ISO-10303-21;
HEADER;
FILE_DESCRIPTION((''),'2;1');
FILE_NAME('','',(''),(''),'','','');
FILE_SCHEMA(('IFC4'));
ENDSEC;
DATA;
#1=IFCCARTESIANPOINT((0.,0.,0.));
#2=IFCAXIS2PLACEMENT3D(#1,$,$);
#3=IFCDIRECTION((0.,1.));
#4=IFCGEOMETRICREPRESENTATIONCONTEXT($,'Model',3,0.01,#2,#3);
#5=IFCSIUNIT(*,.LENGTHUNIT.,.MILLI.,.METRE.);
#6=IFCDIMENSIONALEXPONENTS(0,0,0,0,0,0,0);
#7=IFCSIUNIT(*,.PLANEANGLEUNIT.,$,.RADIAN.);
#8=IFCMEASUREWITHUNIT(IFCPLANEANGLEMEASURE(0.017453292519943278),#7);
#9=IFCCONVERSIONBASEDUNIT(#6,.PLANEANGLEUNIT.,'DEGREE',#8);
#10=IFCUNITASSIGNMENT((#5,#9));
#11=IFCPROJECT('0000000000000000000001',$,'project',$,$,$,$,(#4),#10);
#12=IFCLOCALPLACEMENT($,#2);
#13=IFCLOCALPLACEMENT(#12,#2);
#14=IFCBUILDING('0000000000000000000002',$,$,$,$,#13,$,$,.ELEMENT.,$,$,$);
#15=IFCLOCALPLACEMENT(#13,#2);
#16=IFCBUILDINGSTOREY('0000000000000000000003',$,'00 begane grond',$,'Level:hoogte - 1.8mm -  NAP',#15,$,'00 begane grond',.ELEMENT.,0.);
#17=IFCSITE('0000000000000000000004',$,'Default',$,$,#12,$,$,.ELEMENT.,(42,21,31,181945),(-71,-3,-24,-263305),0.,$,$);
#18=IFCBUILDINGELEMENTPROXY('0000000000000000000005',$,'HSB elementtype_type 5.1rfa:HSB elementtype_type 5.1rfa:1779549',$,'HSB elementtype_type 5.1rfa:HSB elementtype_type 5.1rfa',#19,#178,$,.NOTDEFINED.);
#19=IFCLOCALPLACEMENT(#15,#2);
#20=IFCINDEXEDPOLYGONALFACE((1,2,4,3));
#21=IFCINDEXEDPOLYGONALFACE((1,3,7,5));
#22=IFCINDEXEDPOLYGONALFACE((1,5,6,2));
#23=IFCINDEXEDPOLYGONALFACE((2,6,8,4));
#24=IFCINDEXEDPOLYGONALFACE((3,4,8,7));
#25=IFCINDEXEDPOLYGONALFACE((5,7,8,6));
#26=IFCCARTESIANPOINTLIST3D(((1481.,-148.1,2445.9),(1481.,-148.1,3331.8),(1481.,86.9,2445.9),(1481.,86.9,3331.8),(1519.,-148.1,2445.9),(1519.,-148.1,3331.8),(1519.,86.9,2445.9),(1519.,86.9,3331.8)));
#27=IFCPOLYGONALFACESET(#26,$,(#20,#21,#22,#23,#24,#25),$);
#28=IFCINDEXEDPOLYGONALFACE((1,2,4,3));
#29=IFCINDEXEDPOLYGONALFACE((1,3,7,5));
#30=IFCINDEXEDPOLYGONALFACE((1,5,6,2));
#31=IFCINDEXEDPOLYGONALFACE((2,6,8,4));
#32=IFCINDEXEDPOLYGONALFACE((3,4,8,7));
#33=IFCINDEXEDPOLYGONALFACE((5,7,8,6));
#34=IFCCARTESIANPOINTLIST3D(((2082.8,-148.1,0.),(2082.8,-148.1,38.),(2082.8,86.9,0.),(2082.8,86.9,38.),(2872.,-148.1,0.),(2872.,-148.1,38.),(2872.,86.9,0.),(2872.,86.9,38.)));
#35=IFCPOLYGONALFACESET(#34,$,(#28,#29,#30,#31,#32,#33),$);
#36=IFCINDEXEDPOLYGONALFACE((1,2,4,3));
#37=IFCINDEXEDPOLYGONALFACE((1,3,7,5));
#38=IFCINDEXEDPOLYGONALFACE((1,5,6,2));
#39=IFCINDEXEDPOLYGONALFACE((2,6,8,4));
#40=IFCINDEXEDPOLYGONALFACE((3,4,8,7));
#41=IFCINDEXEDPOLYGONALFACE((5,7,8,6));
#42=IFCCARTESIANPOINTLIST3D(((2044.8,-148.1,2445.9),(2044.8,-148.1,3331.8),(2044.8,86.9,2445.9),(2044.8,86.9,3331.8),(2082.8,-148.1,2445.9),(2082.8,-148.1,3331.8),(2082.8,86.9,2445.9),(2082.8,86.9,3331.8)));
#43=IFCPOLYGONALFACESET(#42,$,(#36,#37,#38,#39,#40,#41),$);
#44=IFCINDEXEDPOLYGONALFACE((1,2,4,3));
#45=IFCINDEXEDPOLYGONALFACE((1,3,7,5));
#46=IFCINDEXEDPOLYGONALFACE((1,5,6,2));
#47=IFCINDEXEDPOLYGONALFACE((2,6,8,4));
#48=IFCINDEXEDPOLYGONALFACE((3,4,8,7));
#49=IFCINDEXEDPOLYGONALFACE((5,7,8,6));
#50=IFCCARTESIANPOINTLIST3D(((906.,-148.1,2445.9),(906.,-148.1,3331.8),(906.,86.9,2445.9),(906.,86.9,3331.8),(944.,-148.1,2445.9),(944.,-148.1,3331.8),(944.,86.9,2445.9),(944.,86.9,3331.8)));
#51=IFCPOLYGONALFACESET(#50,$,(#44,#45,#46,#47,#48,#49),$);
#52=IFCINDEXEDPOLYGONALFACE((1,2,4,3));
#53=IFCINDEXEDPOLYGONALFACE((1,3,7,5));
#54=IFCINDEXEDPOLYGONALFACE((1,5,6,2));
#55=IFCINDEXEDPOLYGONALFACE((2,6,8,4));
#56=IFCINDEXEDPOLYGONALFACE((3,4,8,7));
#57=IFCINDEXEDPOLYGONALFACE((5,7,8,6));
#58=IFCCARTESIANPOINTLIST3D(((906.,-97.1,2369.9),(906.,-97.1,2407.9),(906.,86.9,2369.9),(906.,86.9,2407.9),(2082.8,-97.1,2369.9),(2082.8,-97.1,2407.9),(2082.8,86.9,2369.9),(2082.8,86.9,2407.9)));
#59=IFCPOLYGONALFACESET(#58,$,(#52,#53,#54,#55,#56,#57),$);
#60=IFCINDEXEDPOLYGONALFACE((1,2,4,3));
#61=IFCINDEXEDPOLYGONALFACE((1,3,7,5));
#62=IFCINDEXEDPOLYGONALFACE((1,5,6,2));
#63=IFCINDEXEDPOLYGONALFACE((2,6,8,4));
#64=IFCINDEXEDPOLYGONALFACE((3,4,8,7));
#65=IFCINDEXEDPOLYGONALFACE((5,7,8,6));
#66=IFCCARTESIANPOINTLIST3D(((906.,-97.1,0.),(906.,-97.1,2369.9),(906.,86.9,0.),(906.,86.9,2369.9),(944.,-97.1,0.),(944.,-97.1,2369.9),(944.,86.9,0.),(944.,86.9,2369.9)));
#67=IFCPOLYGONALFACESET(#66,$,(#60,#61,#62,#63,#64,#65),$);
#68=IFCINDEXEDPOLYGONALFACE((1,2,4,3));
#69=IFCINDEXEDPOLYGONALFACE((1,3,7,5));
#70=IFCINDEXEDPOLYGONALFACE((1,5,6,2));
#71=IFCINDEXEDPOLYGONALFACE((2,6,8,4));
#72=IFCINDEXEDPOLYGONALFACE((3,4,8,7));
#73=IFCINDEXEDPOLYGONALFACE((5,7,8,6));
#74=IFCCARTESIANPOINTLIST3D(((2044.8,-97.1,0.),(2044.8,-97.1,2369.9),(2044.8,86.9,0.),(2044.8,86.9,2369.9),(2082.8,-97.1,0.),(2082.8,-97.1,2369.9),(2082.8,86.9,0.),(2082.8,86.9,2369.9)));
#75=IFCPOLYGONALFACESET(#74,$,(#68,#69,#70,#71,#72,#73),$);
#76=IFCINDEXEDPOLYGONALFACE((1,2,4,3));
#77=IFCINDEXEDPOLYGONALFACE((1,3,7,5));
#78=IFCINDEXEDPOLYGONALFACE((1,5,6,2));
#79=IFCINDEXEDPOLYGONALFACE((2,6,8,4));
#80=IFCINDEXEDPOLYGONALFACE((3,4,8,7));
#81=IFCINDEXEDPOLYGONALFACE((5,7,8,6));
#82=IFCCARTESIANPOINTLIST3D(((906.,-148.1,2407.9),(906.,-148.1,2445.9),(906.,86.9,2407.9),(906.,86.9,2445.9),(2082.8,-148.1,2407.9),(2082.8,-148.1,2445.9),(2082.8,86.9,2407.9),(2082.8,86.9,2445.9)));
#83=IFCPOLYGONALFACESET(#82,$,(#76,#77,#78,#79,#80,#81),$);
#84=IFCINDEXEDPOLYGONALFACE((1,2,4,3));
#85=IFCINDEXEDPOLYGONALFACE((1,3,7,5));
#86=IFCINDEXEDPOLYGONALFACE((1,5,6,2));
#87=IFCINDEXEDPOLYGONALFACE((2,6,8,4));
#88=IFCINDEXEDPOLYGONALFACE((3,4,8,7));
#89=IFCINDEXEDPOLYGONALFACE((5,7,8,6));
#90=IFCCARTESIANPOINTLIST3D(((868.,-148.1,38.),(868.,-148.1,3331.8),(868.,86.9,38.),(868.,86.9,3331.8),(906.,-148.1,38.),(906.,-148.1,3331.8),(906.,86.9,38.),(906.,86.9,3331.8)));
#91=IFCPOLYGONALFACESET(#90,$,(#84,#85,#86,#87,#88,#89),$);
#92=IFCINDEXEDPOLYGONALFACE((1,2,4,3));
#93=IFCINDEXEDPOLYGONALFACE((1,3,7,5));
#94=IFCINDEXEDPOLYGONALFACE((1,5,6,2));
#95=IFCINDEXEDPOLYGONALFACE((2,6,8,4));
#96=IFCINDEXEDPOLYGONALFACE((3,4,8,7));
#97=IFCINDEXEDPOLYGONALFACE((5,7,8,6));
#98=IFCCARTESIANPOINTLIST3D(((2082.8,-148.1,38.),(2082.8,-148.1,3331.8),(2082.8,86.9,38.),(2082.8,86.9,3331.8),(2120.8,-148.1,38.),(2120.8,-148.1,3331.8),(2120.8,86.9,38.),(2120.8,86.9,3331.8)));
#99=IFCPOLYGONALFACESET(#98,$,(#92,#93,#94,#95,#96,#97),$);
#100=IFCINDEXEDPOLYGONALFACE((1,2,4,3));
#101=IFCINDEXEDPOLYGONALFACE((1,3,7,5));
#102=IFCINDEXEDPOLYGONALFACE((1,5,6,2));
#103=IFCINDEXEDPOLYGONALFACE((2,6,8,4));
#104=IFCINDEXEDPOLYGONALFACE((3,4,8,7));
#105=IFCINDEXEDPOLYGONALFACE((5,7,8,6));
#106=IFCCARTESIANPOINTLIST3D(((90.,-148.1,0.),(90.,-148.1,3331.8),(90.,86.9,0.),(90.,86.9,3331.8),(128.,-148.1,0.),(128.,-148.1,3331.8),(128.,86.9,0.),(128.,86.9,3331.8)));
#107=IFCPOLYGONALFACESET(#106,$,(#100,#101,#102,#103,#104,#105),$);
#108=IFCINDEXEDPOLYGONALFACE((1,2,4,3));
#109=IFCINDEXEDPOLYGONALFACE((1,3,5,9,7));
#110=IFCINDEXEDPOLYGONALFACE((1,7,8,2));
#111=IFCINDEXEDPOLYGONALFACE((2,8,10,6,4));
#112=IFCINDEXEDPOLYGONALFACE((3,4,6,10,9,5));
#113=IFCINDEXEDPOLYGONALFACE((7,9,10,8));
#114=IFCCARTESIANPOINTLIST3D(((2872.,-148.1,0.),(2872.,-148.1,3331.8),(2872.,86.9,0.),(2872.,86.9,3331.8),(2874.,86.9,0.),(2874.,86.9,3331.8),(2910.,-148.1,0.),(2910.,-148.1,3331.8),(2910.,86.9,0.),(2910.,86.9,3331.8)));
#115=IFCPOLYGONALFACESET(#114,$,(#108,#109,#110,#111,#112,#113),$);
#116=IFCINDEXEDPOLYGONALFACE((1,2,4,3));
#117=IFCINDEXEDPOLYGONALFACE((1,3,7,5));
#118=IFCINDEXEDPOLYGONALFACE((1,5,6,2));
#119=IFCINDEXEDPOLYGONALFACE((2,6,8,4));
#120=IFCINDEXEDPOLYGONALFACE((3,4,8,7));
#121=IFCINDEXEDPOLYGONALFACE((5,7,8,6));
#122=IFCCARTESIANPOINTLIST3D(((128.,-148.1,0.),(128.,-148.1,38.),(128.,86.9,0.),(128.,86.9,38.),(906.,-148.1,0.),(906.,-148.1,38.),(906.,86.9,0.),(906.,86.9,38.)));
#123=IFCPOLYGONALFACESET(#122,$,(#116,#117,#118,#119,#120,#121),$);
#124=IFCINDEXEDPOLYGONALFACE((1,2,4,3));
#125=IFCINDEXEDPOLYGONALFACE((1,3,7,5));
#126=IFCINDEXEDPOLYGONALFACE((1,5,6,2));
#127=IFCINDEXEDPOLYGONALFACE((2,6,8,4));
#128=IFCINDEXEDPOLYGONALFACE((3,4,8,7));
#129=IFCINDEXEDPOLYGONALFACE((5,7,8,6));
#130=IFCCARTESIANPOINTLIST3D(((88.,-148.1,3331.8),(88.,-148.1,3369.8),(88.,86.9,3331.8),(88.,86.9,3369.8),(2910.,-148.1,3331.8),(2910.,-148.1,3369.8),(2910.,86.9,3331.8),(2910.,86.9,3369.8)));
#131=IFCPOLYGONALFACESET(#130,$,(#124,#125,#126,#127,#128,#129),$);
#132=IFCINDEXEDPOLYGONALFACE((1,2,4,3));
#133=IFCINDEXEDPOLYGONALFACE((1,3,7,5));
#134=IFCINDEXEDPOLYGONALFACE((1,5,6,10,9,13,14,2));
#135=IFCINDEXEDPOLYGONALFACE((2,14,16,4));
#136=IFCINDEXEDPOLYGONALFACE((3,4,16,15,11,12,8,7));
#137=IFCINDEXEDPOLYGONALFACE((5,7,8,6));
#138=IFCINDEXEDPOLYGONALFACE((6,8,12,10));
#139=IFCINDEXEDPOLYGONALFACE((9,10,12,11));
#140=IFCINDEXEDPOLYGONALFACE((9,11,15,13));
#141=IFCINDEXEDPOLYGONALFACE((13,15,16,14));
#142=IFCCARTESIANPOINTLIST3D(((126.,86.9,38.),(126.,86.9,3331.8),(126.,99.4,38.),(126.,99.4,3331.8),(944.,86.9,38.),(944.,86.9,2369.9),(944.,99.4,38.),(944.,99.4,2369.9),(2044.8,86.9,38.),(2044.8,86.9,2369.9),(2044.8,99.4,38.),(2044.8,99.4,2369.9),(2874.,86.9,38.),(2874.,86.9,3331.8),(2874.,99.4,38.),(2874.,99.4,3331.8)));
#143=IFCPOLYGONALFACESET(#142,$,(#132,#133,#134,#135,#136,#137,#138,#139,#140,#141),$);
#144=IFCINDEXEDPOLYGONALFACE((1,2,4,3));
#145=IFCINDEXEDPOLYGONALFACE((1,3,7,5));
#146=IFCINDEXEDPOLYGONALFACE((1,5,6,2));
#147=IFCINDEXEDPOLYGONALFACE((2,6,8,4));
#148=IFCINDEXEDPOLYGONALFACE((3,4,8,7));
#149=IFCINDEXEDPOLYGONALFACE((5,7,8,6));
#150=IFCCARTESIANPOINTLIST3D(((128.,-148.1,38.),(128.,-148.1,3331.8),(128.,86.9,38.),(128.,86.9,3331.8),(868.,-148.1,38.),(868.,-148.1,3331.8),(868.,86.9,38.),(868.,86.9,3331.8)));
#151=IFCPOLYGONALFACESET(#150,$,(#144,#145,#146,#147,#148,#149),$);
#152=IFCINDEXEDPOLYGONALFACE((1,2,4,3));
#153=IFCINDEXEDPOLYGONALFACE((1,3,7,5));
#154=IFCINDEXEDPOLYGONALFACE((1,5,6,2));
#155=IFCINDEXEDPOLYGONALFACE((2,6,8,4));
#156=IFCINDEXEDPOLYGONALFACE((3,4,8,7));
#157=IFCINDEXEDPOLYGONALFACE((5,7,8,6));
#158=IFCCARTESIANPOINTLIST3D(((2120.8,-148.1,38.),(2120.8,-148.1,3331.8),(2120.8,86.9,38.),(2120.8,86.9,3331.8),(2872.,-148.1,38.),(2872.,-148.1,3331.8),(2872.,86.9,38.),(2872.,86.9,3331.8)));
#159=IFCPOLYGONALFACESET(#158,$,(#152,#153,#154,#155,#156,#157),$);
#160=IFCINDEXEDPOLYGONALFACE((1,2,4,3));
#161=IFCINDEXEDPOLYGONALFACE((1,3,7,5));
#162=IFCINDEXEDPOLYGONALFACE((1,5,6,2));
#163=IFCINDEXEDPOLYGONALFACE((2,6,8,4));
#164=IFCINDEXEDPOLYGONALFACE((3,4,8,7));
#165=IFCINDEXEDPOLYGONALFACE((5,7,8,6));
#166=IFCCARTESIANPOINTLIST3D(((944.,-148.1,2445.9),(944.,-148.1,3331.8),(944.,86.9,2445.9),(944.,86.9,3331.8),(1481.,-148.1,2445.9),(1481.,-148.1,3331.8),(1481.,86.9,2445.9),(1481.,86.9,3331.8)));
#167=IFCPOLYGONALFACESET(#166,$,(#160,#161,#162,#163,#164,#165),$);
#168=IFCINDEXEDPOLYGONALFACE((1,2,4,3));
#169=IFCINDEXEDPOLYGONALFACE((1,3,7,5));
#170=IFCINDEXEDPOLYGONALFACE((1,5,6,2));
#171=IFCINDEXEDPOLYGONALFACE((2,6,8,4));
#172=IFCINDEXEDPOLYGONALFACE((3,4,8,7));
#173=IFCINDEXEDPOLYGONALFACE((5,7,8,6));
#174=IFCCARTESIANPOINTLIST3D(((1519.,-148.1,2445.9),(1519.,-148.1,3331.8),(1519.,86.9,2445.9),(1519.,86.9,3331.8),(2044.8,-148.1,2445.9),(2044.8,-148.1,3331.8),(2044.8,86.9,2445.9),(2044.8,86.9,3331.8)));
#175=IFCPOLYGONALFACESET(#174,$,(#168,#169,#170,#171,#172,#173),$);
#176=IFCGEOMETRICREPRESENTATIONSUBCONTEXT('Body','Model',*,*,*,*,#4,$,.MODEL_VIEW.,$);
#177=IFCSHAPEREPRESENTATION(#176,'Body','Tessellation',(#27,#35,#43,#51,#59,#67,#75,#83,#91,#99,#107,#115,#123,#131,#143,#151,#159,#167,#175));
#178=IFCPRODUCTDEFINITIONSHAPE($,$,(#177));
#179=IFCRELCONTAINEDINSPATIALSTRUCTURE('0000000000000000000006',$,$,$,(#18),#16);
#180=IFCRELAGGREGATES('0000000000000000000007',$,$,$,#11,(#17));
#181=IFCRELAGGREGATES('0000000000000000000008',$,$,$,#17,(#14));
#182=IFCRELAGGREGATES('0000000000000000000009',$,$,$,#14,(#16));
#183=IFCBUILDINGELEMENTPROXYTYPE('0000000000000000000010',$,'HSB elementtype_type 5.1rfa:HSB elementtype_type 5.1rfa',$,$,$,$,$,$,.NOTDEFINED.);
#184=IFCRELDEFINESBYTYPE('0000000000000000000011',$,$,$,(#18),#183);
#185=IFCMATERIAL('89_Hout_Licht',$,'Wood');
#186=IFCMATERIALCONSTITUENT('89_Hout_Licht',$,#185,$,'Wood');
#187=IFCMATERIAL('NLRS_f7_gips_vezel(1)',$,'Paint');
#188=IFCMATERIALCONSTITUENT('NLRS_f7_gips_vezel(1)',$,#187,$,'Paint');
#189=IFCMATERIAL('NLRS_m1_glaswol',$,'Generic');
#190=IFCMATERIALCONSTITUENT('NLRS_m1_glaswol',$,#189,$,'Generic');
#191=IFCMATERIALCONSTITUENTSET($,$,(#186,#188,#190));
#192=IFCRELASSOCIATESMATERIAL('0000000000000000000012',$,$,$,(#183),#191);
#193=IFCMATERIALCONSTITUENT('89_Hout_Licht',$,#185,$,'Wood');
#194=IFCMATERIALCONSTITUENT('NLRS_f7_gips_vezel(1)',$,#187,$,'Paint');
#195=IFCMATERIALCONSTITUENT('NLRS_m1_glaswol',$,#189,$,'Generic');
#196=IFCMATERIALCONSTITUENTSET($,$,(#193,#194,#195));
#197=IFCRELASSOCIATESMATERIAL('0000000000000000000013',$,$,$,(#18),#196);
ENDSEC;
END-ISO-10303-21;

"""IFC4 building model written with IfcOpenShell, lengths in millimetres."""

from ifc_helpers import new_model, entity, si_unit, converted_unit, direction, frame, origin, place, context, subcontext, project, spatial, indexed_curve, outline, extrude, source, transform, mapped, material, constituent, constituent_set, type_object, type_shapes, element, save


model = new_model("IFC4")

# Units and contexts
model_context = context("Model", 3, precision=0.01, world=origin(), true_north=direction((0.0, 1.0)))
body_context = subcontext(model_context, "Body", "Model", "MODEL_VIEW")
ifc_project = project(units=[si_unit("LENGTHUNIT", "METRE", prefix="MILLI"), converted_unit("PLANEANGLEUNIT", "DEGREE", entity("IfcPlaneAngleMeasure", 0.017453292519943278), si_unit("PLANEANGLEUNIT", "RADIAN"), dimensions=[0, 0, 0, 0, 0, 0, 0])], contexts=[model_context])

# Site, building, storey
site_placement = place(None, origin())
site = spatial("IfcSite", under=ifc_project, at=site_placement, Name="Default", CompositionType="ELEMENT", RefLatitude=(42, 21, 31, 181945), RefLongitude=(-71, -3, -24, -263305), RefElevation=0.0)
building_placement = place(site_placement, origin())
building = spatial("IfcBuilding", under=site, at=building_placement, CompositionType="ELEMENT")
storey_placement = place(building_placement, origin())
storey = spatial("IfcBuildingStorey", under=building, at=storey_placement, Name="00 begane grond", ObjectType="Level:hoogte - 1.8mm -  NAP", LongName="00 begane grond", CompositionType="ELEMENT", Elevation=0.0)

# Shared definitions
ifc_material_1 = material(Name="NLRS_f7_gips_vezel(1)", Category="Paint")

# Shared definitions
ifc_material_2 = material(Name="NLRS_m1_glaswol", Category="Generic")

# Building element proxy
ifc_material_3 = material(Name="89_Hout_Licht", Category="Wood")
ifc_constituent_1 = constituent(ifc_material_3, Name="89_Hout_Licht", Category="Wood")
ifc_constituent_2 = constituent(ifc_material_1, Name="NLRS_f7_gips_vezel(1)", Category="Paint")
ifc_constituent_3 = constituent(ifc_material_2, Name="NLRS_m1_glaswol", Category="Generic")
ifc_constituent_set_1 = constituent_set(constituents=[ifc_constituent_1, ifc_constituent_2, ifc_constituent_3])
ifc_constituent_4 = constituent(ifc_material_3, Name="89_Hout_Licht", Category="Wood")
ifc_constituent_5 = constituent(ifc_material_1, Name="NLRS_f7_gips_vezel(1)", Category="Paint")
ifc_constituent_6 = constituent(ifc_material_2, Name="NLRS_m1_glaswol", Category="Generic")
ifc_constituent_set_2 = constituent_set(constituents=[ifc_constituent_4, ifc_constituent_5, ifc_constituent_6])
building_element_proxy_type_1 = type_object("IfcBuildingElementProxyType", Name="HSB elementtype_type 5.1rfa:HSB elementtype_type 5.1rfa", PredefinedType="NOTDEFINED", material=ifc_constituent_set_2)
shared_shape_1 = source(origin(), body_context, "Body", "SweptSolid", [
    extrude(outline(indexed_curve([(-117.5, -19.0), (117.5, -19.0), (117.5, 19.0), (-117.5, 19.0), (-117.5, -19.0)], self_intersect=False)), frame((1500.0, -30.6, 2445.9), z_axis=(0.0, 0.0, 1.0), x_axis=(0.0, 1.0, 0.0)), (0.0, 0.0, 1.0), 885.9),
    extrude(outline(indexed_curve([(-117.5, -394.6), (117.5, -394.6), (117.5, 394.6), (-117.5, 394.6), (-117.5, -394.6)], self_intersect=False)), frame((2477.4, -30.6, 0.0), z_axis=(0.0, 0.0, 1.0), x_axis=(0.0, 1.0, 0.0)), (0.0, 0.0, 1.0), 38.0),
    extrude(outline(indexed_curve([(-117.5, -19.0), (117.5, -19.0), (117.5, 19.0), (-117.5, 19.0), (-117.5, -19.0)], self_intersect=False)), frame((2063.8, -30.6, 2445.9), z_axis=(0.0, 0.0, 1.0), x_axis=(0.0, 1.0, 0.0)), (0.0, 0.0, 1.0), 885.9),
    extrude(outline(indexed_curve([(-117.5, -19.0), (117.5, -19.0), (117.5, 19.0), (-117.5, 19.0), (-117.5, -19.0)], self_intersect=False)), frame((925.0, -30.6, 2445.9), z_axis=(0.0, 0.0, 1.0), x_axis=(0.0, 1.0, 0.0)), (0.0, 0.0, 1.0), 885.9),
    extrude(outline(indexed_curve([(-92.0, -588.4), (92.0, -588.4), (92.0, 588.4), (-92.0, 588.4), (-92.0, -588.4)], self_intersect=False)), frame((1494.4, -5.1, 2369.9), z_axis=(0.0, 0.0, 1.0), x_axis=(0.0, 1.0, 0.0)), (0.0, 0.0, 1.0), 38.0),
    extrude(outline(indexed_curve([(-92.0, -19.0), (92.0, -19.0), (92.0, 19.0), (-92.0, 19.0), (-92.0, -19.0)], self_intersect=False)), frame((925.0, -5.1, 0.0), z_axis=(0.0, 0.0, 1.0), x_axis=(0.0, 1.0, 0.0)), (0.0, 0.0, 1.0), 2369.9),
    extrude(outline(indexed_curve([(-92.0, -19.0), (92.0, -19.0), (92.0, 19.0), (-92.0, 19.0), (-92.0, -19.0)], self_intersect=False)), frame((2063.8, -5.1, 0.0), z_axis=(0.0, 0.0, 1.0), x_axis=(0.0, 1.0, 0.0)), (0.0, 0.0, 1.0), 2369.9),
    extrude(outline(indexed_curve([(-117.5, -588.4), (117.5, -588.4), (117.5, 588.4), (-117.5, 588.4), (-117.5, -588.4)], self_intersect=False)), frame((1494.4, -30.6, 2407.9), z_axis=(0.0, 0.0, 1.0), x_axis=(0.0, 1.0, 0.0)), (0.0, 0.0, 1.0), 38.0),
    extrude(outline(indexed_curve([(-117.5, -19.0), (117.5, -19.0), (117.5, 19.0), (-117.5, 19.0), (-117.5, -19.0)], self_intersect=False)), frame((887.0, -30.6, 38.0), z_axis=(0.0, 0.0, 1.0), x_axis=(0.0, 1.0, 0.0)), (0.0, 0.0, 1.0), 3293.8),
    extrude(outline(indexed_curve([(-117.5, -19.0), (117.5, -19.0), (117.5, 19.0), (-117.5, 19.0), (-117.5, -19.0)], self_intersect=False)), frame((2101.8, -30.6, 38.0), z_axis=(0.0, 0.0, 1.0), x_axis=(0.0, 1.0, 0.0)), (0.0, 0.0, 1.0), 3293.8),
    extrude(outline(indexed_curve([(-117.5, -19.0), (117.5, -19.0), (117.5, 19.0), (-117.5, 19.0), (-117.5, -19.0)], self_intersect=False)), frame((109.0, -30.6, 0.0), z_axis=(0.0, 0.0, 1.0), x_axis=(0.0, 1.0, 0.0)), (0.0, 0.0, 1.0), 3331.8),
    extrude(outline(indexed_curve([(-141.0, -22.4), (94.0, -22.4), (94.0, 13.6), (94.0, 15.6), (-141.0, 15.6), (-141.0, -22.4)], self_intersect=False)), frame((2887.6, -7.1, 0.0), z_axis=(0.0, 0.0, 1.0), x_axis=(0.0, 1.0, 0.0)), (0.0, 0.0, 1.0), 3331.8),
    extrude(outline(indexed_curve([(-117.5, -389.0), (117.5, -389.0), (117.5, 389.0), (-117.5, 389.0), (-117.5, -389.0)], self_intersect=False)), frame((517.0, -30.6, 0.0), z_axis=(0.0, 0.0, 1.0), x_axis=(0.0, 1.0, 0.0)), (0.0, 0.0, 1.0), 38.0),
    extrude(outline(indexed_curve([(-117.5, -1411.0), (117.5, -1411.0), (117.5, 1411.0), (-117.5, 1411.0), (-117.5, -1411.0)], self_intersect=False)), frame((1499.0, -30.6, 3331.8), z_axis=(0.0, 0.0, 1.0), x_axis=(0.0, 1.0, 0.0)), (0.0, 0.0, 1.0), 38.0),
    extrude(outline(indexed_curve([(-1887.4, -1376.8), (1406.4, -1376.8), (1406.4, -547.7), (-925.5, -547.7), (-925.5, 553.2), (1406.4, 553.2), (1406.4, 1371.2), (-1887.4, 1371.2), (-1887.4, -1376.8)], self_intersect=False)), frame((1497.2, 86.9, 1444.4), z_axis=(0.0, 1.0, 0.0), x_axis=(0.0, 0.0, -1.0)), (0.0, 0.0, 1.0), 12.5),
    extrude(outline(indexed_curve([(-117.5, -370.0), (117.5, -370.0), (117.5, 370.0), (-117.5, 370.0), (-117.5, -370.0)], self_intersect=False)), frame((498.0, -30.6, 38.0), z_axis=(0.0, 0.0, 1.0), x_axis=(0.0, 1.0, 0.0)), (0.0, 0.0, 1.0), 3293.8),
    extrude(outline(indexed_curve([(-117.5, -375.6), (117.5, -375.6), (117.5, 375.6), (-117.5, 375.6), (-117.5, -375.6)], self_intersect=False)), frame((2496.4, -30.6, 38.0), z_axis=(0.0, 0.0, 1.0), x_axis=(0.0, 1.0, 0.0)), (0.0, 0.0, 1.0), 3293.8),
    extrude(outline(indexed_curve([(-117.5, -268.5), (117.5, -268.5), (117.5, 268.5), (-117.5, 268.5), (-117.5, -268.5)], self_intersect=False)), frame((1212.5, -30.6, 2445.9), z_axis=(0.0, 0.0, 1.0), x_axis=(0.0, 1.0, 0.0)), (0.0, 0.0, 1.0), 885.9),
    extrude(outline(indexed_curve([(-117.5, -262.9), (117.5, -262.9), (117.5, 262.9), (-117.5, 262.9), (-117.5, -262.9)], self_intersect=False)), frame((1781.9, -30.6, 2445.9), z_axis=(0.0, 0.0, 1.0), x_axis=(0.0, 1.0, 0.0)), (0.0, 0.0, 1.0), 885.9),
])
type_shapes(building_element_proxy_type_1, [shared_shape_1])
proxy_1_placement = place(storey_placement, origin())
element("IfcBuildingElementProxy", 1, at=proxy_1_placement, inside=storey, type_object=building_element_proxy_type_1, material=ifc_constituent_set_1, Name="HSB elementtype_type 5.1rfa:HSB elementtype_type 5.1rfa:1779549", ObjectType="HSB elementtype_type 5.1rfa:HSB elementtype_type 5.1rfa", PredefinedType="NOTDEFINED", context=body_context, shape_type="MappedRepresentation", body=[
    mapped(shared_shape_1, transform((0.0, 0.0, 0.0), scale=1.0)),
])

save(model, "model.ifc")
